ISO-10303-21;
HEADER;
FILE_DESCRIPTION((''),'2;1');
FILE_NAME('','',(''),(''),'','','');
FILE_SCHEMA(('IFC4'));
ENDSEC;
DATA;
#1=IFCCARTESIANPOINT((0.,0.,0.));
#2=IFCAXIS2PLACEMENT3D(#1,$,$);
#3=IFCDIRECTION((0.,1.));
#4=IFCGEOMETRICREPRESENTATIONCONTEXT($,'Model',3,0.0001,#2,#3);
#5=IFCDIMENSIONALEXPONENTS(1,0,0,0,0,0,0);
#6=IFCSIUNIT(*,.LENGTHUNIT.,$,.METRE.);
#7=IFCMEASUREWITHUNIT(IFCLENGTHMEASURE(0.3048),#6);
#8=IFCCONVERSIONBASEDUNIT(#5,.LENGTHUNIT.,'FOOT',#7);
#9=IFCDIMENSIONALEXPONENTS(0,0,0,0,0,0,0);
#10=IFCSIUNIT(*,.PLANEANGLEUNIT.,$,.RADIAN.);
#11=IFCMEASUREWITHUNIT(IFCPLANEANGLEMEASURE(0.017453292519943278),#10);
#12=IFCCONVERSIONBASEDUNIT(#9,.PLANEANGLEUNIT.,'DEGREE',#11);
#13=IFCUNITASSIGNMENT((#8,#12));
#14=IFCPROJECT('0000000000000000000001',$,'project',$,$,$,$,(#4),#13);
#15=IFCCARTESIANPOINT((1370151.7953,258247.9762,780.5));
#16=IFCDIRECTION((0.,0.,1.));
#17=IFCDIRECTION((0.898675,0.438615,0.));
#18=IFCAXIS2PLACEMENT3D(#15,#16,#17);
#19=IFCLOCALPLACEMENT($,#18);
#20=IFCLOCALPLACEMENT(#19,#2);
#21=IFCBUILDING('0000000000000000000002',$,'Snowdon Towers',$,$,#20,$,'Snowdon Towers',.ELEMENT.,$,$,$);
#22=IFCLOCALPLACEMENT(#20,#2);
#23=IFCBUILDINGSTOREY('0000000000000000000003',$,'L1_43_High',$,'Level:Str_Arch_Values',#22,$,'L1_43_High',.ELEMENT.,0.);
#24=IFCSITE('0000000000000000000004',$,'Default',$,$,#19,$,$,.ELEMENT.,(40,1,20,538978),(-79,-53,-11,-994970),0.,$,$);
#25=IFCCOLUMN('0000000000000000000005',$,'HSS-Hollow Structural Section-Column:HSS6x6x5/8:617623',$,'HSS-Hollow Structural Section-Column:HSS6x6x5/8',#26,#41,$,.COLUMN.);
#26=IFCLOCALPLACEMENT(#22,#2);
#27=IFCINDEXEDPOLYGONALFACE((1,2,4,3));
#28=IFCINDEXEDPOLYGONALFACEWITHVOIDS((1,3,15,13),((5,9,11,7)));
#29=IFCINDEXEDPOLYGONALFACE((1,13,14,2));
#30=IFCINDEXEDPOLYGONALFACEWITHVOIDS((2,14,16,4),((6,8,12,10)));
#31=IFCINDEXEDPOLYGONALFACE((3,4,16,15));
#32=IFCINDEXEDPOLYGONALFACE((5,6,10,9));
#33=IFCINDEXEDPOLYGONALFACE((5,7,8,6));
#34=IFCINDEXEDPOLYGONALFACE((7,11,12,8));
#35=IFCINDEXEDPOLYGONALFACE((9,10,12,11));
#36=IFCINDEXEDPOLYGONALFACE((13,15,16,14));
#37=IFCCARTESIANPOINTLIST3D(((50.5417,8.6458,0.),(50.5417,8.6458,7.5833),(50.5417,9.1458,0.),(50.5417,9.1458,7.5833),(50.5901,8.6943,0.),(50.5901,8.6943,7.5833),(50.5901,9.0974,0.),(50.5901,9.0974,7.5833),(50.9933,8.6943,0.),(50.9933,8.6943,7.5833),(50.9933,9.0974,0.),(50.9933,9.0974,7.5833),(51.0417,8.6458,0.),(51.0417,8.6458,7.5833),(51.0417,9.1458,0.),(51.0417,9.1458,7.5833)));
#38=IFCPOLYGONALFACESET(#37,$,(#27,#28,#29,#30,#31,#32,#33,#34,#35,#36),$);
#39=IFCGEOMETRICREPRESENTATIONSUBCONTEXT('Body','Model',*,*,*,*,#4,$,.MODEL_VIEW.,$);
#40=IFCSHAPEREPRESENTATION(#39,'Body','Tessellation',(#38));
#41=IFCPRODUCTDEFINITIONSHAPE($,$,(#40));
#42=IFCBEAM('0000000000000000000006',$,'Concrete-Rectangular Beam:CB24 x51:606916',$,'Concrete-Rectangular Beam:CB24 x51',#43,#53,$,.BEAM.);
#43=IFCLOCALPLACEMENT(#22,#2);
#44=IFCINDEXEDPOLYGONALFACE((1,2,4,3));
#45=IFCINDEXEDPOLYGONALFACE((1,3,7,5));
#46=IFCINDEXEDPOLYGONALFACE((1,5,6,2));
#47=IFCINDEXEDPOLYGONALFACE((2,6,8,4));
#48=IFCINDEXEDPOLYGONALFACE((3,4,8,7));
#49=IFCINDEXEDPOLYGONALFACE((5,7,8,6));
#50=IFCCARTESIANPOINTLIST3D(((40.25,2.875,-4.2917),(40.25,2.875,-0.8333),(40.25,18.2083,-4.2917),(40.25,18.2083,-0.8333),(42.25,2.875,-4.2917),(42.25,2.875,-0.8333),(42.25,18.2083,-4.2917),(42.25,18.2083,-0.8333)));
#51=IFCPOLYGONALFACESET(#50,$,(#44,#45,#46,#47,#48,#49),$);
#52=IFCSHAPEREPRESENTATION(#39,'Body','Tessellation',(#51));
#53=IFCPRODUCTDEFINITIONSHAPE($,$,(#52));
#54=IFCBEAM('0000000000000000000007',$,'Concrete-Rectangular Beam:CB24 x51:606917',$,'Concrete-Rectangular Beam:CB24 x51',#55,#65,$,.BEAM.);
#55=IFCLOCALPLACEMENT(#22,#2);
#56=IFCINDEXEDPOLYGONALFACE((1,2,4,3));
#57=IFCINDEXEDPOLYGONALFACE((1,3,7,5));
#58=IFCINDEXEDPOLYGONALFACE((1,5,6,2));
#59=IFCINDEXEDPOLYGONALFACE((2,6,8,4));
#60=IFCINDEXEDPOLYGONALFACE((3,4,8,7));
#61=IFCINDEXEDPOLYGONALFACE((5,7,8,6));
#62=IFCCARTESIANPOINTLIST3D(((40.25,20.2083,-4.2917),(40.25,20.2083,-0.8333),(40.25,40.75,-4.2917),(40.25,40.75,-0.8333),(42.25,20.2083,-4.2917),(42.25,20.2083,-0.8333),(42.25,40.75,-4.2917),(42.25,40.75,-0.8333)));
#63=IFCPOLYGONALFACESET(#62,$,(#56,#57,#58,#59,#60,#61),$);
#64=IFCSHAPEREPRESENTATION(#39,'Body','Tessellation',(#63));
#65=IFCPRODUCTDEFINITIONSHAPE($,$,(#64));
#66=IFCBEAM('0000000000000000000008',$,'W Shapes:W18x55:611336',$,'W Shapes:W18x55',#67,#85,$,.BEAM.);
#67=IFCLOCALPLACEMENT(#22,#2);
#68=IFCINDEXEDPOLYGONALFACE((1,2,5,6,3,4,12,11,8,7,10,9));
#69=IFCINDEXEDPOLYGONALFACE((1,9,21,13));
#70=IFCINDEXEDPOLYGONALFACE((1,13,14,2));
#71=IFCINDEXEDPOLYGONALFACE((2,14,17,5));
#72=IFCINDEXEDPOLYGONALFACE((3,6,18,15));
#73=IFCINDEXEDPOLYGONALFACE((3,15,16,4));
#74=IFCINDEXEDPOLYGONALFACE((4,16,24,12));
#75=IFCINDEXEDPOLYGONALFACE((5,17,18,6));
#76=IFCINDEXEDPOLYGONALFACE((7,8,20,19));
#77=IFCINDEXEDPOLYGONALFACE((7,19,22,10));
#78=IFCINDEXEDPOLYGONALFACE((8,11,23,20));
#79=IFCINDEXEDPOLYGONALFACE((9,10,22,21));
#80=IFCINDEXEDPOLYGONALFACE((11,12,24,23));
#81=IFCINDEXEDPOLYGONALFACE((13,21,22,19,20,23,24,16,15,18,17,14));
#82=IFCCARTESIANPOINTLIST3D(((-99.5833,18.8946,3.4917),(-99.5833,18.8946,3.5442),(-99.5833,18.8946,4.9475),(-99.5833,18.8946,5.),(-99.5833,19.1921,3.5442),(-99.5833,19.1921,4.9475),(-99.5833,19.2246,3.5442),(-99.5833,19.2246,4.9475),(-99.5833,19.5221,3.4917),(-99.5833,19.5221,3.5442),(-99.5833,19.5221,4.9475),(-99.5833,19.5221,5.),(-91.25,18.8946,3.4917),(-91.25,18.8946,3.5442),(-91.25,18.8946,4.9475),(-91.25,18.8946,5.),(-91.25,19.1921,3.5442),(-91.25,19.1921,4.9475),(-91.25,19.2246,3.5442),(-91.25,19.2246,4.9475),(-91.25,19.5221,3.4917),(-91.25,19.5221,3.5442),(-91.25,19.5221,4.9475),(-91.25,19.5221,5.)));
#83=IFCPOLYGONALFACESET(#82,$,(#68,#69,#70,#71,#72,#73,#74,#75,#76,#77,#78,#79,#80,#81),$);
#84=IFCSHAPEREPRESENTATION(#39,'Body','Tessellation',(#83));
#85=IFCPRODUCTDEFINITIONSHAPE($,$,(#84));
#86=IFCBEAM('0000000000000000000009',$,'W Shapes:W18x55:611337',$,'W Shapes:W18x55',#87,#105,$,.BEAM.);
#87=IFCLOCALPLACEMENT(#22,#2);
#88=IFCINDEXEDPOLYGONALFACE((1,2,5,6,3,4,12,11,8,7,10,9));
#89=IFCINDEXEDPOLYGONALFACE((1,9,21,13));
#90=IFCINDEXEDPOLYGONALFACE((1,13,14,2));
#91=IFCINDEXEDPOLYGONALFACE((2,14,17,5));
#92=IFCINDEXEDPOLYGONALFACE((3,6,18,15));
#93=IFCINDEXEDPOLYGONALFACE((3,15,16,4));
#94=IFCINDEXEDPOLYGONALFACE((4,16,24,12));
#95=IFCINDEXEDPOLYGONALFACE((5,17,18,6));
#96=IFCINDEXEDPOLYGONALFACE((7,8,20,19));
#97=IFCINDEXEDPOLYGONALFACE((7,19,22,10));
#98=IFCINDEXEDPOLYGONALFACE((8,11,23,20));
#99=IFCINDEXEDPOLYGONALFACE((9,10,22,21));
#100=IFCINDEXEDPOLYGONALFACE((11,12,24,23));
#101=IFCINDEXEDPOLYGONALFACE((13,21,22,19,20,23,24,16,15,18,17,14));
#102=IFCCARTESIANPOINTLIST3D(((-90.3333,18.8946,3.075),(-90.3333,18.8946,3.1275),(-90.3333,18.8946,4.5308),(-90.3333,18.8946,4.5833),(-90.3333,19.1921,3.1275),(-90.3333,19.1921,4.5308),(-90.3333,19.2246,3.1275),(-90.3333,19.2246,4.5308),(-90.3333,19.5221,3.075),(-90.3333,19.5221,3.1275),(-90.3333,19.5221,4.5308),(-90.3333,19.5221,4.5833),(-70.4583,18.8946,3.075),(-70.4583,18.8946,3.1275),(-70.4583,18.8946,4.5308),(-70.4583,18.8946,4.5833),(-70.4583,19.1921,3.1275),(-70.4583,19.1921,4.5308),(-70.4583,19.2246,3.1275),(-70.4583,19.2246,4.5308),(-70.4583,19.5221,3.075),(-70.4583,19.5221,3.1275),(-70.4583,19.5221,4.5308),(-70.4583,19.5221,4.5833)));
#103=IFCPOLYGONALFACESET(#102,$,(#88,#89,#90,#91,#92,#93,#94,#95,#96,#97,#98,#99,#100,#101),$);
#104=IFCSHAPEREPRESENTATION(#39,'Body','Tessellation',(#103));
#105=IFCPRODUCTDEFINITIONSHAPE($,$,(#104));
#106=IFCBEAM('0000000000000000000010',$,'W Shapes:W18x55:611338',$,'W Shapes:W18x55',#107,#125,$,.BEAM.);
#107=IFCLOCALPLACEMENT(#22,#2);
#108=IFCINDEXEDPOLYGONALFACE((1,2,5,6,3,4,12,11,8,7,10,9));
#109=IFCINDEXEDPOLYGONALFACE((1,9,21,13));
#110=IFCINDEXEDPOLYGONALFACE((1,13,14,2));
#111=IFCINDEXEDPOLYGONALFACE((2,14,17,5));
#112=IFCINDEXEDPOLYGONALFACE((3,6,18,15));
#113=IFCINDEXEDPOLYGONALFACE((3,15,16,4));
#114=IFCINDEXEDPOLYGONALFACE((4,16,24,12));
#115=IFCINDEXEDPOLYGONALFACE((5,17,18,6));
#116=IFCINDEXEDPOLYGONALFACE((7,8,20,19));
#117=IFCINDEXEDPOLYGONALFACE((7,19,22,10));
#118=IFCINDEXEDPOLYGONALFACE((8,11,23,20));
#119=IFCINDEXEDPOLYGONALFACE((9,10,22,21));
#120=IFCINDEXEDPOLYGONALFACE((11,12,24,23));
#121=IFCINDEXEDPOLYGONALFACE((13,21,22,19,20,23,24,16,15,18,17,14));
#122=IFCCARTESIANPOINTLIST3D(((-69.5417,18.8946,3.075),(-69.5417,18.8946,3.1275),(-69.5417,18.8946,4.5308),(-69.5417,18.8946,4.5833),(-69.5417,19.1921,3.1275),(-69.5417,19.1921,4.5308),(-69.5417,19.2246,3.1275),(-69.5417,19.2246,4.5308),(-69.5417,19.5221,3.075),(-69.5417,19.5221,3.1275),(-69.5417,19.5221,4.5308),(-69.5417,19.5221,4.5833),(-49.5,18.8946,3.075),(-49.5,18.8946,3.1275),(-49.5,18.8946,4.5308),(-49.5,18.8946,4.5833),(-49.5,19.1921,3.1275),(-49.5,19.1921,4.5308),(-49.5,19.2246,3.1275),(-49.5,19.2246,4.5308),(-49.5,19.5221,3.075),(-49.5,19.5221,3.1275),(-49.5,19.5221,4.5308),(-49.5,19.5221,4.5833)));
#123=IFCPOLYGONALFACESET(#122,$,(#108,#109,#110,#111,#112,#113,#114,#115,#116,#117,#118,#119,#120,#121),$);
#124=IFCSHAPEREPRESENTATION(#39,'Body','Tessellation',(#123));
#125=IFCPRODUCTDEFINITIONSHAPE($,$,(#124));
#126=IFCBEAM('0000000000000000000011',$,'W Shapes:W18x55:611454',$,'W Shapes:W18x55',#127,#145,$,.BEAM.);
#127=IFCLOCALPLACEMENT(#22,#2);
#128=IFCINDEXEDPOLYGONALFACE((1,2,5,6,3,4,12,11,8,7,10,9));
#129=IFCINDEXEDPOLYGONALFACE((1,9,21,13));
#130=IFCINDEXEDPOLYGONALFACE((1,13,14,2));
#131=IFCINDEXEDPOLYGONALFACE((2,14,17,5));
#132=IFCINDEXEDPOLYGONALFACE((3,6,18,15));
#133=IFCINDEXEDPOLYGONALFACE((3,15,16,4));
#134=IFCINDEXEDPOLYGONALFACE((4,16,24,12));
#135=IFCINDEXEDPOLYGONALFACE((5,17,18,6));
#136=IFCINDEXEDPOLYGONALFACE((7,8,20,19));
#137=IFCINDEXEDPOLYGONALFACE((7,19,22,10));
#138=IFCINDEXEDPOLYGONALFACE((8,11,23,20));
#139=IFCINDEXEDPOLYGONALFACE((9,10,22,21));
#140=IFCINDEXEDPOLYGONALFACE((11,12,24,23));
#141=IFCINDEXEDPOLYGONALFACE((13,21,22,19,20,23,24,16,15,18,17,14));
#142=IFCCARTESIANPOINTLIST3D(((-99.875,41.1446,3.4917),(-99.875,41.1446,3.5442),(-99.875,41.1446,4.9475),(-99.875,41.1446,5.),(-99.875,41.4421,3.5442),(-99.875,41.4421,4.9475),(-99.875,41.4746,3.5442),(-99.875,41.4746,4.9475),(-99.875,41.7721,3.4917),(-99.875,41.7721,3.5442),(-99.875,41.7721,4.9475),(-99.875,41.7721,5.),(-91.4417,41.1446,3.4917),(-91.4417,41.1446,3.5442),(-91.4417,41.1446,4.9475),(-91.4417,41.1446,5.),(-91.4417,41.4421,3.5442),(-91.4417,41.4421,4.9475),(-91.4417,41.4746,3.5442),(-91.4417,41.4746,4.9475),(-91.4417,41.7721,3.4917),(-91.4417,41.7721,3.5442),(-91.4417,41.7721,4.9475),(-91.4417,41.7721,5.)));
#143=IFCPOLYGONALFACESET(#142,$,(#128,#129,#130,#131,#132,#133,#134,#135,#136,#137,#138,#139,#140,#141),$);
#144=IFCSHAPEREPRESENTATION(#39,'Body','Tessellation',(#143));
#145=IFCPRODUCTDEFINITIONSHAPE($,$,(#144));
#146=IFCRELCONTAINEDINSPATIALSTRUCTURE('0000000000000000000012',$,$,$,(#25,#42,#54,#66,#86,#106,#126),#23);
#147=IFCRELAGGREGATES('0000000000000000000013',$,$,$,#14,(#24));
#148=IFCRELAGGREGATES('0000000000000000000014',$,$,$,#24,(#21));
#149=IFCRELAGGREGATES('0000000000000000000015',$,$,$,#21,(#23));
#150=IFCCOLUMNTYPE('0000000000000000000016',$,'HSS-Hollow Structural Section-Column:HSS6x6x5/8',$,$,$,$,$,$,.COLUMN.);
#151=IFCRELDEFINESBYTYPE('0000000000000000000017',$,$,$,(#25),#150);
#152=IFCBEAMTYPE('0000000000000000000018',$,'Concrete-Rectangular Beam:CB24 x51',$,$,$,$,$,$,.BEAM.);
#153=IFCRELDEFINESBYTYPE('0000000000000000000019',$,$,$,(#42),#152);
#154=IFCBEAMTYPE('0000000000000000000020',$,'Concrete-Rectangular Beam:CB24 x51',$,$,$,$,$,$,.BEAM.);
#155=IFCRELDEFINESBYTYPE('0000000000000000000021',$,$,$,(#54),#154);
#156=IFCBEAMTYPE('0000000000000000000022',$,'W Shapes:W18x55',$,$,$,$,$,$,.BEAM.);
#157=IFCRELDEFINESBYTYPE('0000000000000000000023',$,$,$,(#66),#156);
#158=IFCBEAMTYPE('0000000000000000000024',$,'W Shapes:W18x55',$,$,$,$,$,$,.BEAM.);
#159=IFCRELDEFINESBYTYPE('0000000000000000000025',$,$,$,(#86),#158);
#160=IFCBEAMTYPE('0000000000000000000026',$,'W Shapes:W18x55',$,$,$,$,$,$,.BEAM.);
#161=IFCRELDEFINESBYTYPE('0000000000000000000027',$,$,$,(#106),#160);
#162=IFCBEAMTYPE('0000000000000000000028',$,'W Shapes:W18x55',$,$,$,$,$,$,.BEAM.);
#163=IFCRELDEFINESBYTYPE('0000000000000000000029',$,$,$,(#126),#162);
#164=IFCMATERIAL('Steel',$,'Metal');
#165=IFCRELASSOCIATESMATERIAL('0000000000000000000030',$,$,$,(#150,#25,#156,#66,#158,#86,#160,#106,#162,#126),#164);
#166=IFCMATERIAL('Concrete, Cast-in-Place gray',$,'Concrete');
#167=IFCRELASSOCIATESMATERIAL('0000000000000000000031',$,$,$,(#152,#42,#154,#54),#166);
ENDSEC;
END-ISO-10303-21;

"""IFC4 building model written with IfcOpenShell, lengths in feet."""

from ifc_helpers import new_model, entity, si_unit, converted_unit, direction, frame, origin, place, context, subcontext, project, spatial, indexed_curve, outline, extrude, source, transform, mapped, material, type_object, type_shapes, element, save


model = new_model("IFC4")

# Units and contexts
model_context = context("Model", 3, precision=0.0001, world=origin(), true_north=direction((0.0, 1.0)))
body_context = subcontext(model_context, "Body", "Model", "MODEL_VIEW")
ifc_project = project(units=[converted_unit("LENGTHUNIT", "FOOT", entity("IfcLengthMeasure", 0.3048), si_unit("LENGTHUNIT", "METRE"), dimensions=[1, 0, 0, 0, 0, 0, 0]), converted_unit("PLANEANGLEUNIT", "DEGREE", entity("IfcPlaneAngleMeasure", 0.017453292519943278), si_unit("PLANEANGLEUNIT", "RADIAN"), dimensions=[0, 0, 0, 0, 0, 0, 0])], contexts=[model_context])

# Site, building, storey
site_placement = place(None, frame((1370151.7953, 258247.9762, 780.5), z_axis=(0.0, 0.0, 1.0), x_axis=(0.898675, 0.438615, 0.0)))
site = spatial("IfcSite", under=ifc_project, at=site_placement, Name="Default", CompositionType="ELEMENT", RefLatitude=(40, 1, 20, 538978), RefLongitude=(-79, -53, -11, -994970), RefElevation=0.0)
building_placement = place(site_placement, origin())
building = spatial("IfcBuilding", under=site, at=building_placement, Name="Snowdon Towers", LongName="Snowdon Towers", CompositionType="ELEMENT")
storey_placement = place(building_placement, origin())
storey = spatial("IfcBuildingStorey", under=building, at=storey_placement, Name="L1_43_High", ObjectType="Level:Str_Arch_Values", LongName="L1_43_High", CompositionType="ELEMENT", Elevation=0.0)

# Column
ifc_material_1 = material(Name="Steel", Category="Metal")
column_type_1 = type_object("IfcColumnType", Name="HSS-Hollow Structural Section-Column:HSS6x6x5/8", PredefinedType="COLUMN", material=ifc_material_1)
shared_shape_1 = source(origin(), body_context, "Body", "SweptSolid", [
    extrude(outline(indexed_curve([(-0.25, -0.25), (0.25, -0.25), (0.25, 0.25), (-0.25, 0.25), (-0.25, -0.25)], self_intersect=False), holes=[indexed_curve([(-0.2016, -0.2016), (-0.2016, 0.2016), (0.2016, 0.2016), (0.2016, -0.2016), (-0.2016, -0.2016)], self_intersect=False)]), frame((0.0, 0.0, 0.0), z_axis=(0.0, 0.0, 1.0), x_axis=(-1.0, 0.0, 0.0)), (0.0, 0.0, 1.0), 7.5833),
])
type_shapes(column_type_1, [shared_shape_1])
column_1_placement = place(storey_placement, frame((50.7917, 8.8958, 0.0), z_axis=(0.0, 0.0, 1.0), x_axis=(0.0, 1.0, 0.0)))
element("IfcColumn", 1, at=column_1_placement, inside=storey, type_object=column_type_1, material=ifc_material_1, Name="HSS-Hollow Structural Section-Column:HSS6x6x5/8:617623", ObjectType="HSS-Hollow Structural Section-Column:HSS6x6x5/8", PredefinedType="COLUMN", context=body_context, shape_type="MappedRepresentation", body=[
    mapped(shared_shape_1, transform((0.0, 0.0, 0.0), scale=1.0)),
])

# Beams
ifc_material_2 = material(Name="Concrete, Cast-in-Place gray", Category="Concrete")
beam_type_1 = type_object("IfcBeamType", Name="Concrete-Rectangular Beam:CB24 x51", PredefinedType="BEAM", material=ifc_material_2)
shared_shape_2 = source(origin(), body_context, "Body", "SweptSolid", [
    extrude(outline(indexed_curve([(-1.0, -1.7292), (1.0, -1.7292), (1.0, 1.7292), (-1.0, 1.7292), (-1.0, -1.7292)], self_intersect=False)), frame((41.25, 2.875, -2.5625), z_axis=(0.0, 1.0, 0.0), x_axis=(-1.0, 0.0, 0.0)), (0.0, 0.0, 1.0), 15.3333),
])
type_shapes(beam_type_1, [shared_shape_2])
beam_1_placement = place(storey_placement, origin())
element("IfcBeam", 2, at=beam_1_placement, inside=storey, type_object=beam_type_1, material=ifc_material_2, Name="Concrete-Rectangular Beam:CB24 x51:606916", ObjectType="Concrete-Rectangular Beam:CB24 x51", PredefinedType="BEAM", context=body_context, shape_type="MappedRepresentation", body=[
    mapped(shared_shape_2, transform((0.0, 0.0, 0.0), scale=1.0)),
])
beam_type_2 = type_object("IfcBeamType", Name="Concrete-Rectangular Beam:CB24 x51", PredefinedType="BEAM", material=ifc_material_2)
shared_shape_3 = source(origin(), body_context, "Body", "SweptSolid", [
    extrude(outline(indexed_curve([(-1.0, -1.7292), (1.0, -1.7292), (1.0, 1.7292), (-1.0, 1.7292), (-1.0, -1.7292)], self_intersect=False)), frame((41.25, 20.2083, -2.5625), z_axis=(0.0, 1.0, 0.0), x_axis=(-1.0, 0.0, 0.0)), (0.0, 0.0, 1.0), 20.5417),
])
type_shapes(beam_type_2, [shared_shape_3])
beam_2_placement = place(storey_placement, origin())
element("IfcBeam", 3, at=beam_2_placement, inside=storey, type_object=beam_type_2, material=ifc_material_2, Name="Concrete-Rectangular Beam:CB24 x51:606917", ObjectType="Concrete-Rectangular Beam:CB24 x51", PredefinedType="BEAM", context=body_context, shape_type="MappedRepresentation", body=[
    mapped(shared_shape_3, transform((0.0, 0.0, 0.0), scale=1.0)),
])
beam_type_3 = type_object("IfcBeamType", Name="W Shapes:W18x55", PredefinedType="BEAM", material=ifc_material_1)
shared_shape_4 = source(origin(), body_context, "Body", "SweptSolid", [
    extrude(outline(indexed_curve([(-0.3138, -0.7017), (-0.3138, -0.7542), (0.3138, -0.7542), (0.3138, -0.7017), (0.0162, -0.7017), (0.0162, 0.7017), (0.3138, 0.7017), (0.3138, 0.7542), (-0.3137, 0.7542), (-0.3137, 0.7017), (-0.0163, 0.7017), (-0.0163, -0.7017), (-0.3138, -0.7017)], self_intersect=False)), frame((-4.125, 0.0, 0.0), z_axis=(-1.0, 0.0, 0.0), x_axis=(0.0, -1.0, 0.0)), (0.0, 0.0, -1.0), 8.3333),
])
type_shapes(beam_type_3, [shared_shape_4])
beam_3_placement = place(storey_placement, frame((-95.4583, 19.2083, 4.2458)))
element("IfcBeam", 4, at=beam_3_placement, inside=storey, type_object=beam_type_3, material=ifc_material_1, Name="W Shapes:W18x55:611336", ObjectType="W Shapes:W18x55", PredefinedType="BEAM", context=body_context, shape_type="MappedRepresentation", body=[
    mapped(shared_shape_4, transform((0.0, 0.0, 0.0), scale=1.0)),
])
beam_type_4 = type_object("IfcBeamType", Name="W Shapes:W18x55", PredefinedType="BEAM", material=ifc_material_1)
shared_shape_5 = source(origin(), body_context, "Body", "SweptSolid", [
    extrude(outline(indexed_curve([(-0.3138, -0.7017), (-0.3138, -0.7542), (0.3138, -0.7542), (0.3138, -0.7017), (0.0162, -0.7017), (0.0162, 0.7017), (0.3138, 0.7017), (0.3138, 0.7542), (-0.3137, 0.7542), (-0.3137, 0.7017), (-0.0163, 0.7017), (-0.0163, -0.7017), (-0.3138, -0.7017)], self_intersect=False)), frame((-9.9375, 0.0, 0.0), z_axis=(-1.0, 0.0, 0.0), x_axis=(0.0, -1.0, 0.0)), (0.0, 0.0, -1.0), 19.875),
])
type_shapes(beam_type_4, [shared_shape_5])
beam_4_placement = place(storey_placement, frame((-80.3958, 19.2083, 3.8292)))
element("IfcBeam", 5, at=beam_4_placement, inside=storey, type_object=beam_type_4, material=ifc_material_1, Name="W Shapes:W18x55:611337", ObjectType="W Shapes:W18x55", PredefinedType="BEAM", context=body_context, shape_type="MappedRepresentation", body=[
    mapped(shared_shape_5, transform((0.0, 0.0, 0.0), scale=1.0)),
])
beam_type_5 = type_object("IfcBeamType", Name="W Shapes:W18x55", PredefinedType="BEAM", material=ifc_material_1)
shared_shape_6 = source(origin(), body_context, "Body", "SweptSolid", [
    extrude(outline(indexed_curve([(-0.3138, -0.7017), (-0.3138, -0.7542), (0.3138, -0.7542), (0.3138, -0.7017), (0.0162, -0.7017), (0.0162, 0.7017), (0.3138, 0.7017), (0.3138, 0.7542), (-0.3137, 0.7542), (-0.3137, 0.7017), (-0.0163, 0.7017), (-0.0163, -0.7017), (-0.3138, -0.7017)], self_intersect=False)), frame((-9.8333, 0.0, 0.0), z_axis=(-1.0, 0.0, 0.0), x_axis=(0.0, -1.0, 0.0)), (0.0, 0.0, -1.0), 20.0417),
])
type_shapes(beam_type_5, [shared_shape_6])
beam_5_placement = place(storey_placement, frame((-59.7083, 19.2083, 3.8292)))
element("IfcBeam", 6, at=beam_5_placement, inside=storey, type_object=beam_type_5, material=ifc_material_1, Name="W Shapes:W18x55:611338", ObjectType="W Shapes:W18x55", PredefinedType="BEAM", context=body_context, shape_type="MappedRepresentation", body=[
    mapped(shared_shape_6, transform((0.0, 0.0, 0.0), scale=1.0)),
])
beam_type_6 = type_object("IfcBeamType", Name="W Shapes:W18x55", PredefinedType="BEAM", material=ifc_material_1)
shared_shape_7 = source(origin(), body_context, "Body", "SweptSolid", [
    extrude(outline(indexed_curve([(-0.3138, -0.7017), (-0.3138, -0.7542), (0.3138, -0.7542), (0.3138, -0.7017), (0.0162, -0.7017), (0.0162, 0.7017), (0.3138, 0.7017), (0.3138, 0.7542), (-0.3137, 0.7542), (-0.3137, 0.7017), (-0.0163, 0.7017), (-0.0163, -0.7017), (-0.3138, -0.7017)], self_intersect=False)), frame((-4.4375, 0.0, 0.0), z_axis=(-1.0, 0.0, 0.0), x_axis=(0.0, -1.0, 0.0)), (0.0, 0.0, -1.0), 8.4333),
])
type_shapes(beam_type_6, [shared_shape_7])
beam_6_placement = place(storey_placement, frame((-95.4375, 41.4583, 4.2458)))
element("IfcBeam", 7, at=beam_6_placement, inside=storey, type_object=beam_type_6, material=ifc_material_1, Name="W Shapes:W18x55:611454", ObjectType="W Shapes:W18x55", PredefinedType="BEAM", context=body_context, shape_type="MappedRepresentation", body=[
    mapped(shared_shape_7, transform((0.0, 0.0, 0.0), scale=1.0)),
])

save(model, "model.ifc")
